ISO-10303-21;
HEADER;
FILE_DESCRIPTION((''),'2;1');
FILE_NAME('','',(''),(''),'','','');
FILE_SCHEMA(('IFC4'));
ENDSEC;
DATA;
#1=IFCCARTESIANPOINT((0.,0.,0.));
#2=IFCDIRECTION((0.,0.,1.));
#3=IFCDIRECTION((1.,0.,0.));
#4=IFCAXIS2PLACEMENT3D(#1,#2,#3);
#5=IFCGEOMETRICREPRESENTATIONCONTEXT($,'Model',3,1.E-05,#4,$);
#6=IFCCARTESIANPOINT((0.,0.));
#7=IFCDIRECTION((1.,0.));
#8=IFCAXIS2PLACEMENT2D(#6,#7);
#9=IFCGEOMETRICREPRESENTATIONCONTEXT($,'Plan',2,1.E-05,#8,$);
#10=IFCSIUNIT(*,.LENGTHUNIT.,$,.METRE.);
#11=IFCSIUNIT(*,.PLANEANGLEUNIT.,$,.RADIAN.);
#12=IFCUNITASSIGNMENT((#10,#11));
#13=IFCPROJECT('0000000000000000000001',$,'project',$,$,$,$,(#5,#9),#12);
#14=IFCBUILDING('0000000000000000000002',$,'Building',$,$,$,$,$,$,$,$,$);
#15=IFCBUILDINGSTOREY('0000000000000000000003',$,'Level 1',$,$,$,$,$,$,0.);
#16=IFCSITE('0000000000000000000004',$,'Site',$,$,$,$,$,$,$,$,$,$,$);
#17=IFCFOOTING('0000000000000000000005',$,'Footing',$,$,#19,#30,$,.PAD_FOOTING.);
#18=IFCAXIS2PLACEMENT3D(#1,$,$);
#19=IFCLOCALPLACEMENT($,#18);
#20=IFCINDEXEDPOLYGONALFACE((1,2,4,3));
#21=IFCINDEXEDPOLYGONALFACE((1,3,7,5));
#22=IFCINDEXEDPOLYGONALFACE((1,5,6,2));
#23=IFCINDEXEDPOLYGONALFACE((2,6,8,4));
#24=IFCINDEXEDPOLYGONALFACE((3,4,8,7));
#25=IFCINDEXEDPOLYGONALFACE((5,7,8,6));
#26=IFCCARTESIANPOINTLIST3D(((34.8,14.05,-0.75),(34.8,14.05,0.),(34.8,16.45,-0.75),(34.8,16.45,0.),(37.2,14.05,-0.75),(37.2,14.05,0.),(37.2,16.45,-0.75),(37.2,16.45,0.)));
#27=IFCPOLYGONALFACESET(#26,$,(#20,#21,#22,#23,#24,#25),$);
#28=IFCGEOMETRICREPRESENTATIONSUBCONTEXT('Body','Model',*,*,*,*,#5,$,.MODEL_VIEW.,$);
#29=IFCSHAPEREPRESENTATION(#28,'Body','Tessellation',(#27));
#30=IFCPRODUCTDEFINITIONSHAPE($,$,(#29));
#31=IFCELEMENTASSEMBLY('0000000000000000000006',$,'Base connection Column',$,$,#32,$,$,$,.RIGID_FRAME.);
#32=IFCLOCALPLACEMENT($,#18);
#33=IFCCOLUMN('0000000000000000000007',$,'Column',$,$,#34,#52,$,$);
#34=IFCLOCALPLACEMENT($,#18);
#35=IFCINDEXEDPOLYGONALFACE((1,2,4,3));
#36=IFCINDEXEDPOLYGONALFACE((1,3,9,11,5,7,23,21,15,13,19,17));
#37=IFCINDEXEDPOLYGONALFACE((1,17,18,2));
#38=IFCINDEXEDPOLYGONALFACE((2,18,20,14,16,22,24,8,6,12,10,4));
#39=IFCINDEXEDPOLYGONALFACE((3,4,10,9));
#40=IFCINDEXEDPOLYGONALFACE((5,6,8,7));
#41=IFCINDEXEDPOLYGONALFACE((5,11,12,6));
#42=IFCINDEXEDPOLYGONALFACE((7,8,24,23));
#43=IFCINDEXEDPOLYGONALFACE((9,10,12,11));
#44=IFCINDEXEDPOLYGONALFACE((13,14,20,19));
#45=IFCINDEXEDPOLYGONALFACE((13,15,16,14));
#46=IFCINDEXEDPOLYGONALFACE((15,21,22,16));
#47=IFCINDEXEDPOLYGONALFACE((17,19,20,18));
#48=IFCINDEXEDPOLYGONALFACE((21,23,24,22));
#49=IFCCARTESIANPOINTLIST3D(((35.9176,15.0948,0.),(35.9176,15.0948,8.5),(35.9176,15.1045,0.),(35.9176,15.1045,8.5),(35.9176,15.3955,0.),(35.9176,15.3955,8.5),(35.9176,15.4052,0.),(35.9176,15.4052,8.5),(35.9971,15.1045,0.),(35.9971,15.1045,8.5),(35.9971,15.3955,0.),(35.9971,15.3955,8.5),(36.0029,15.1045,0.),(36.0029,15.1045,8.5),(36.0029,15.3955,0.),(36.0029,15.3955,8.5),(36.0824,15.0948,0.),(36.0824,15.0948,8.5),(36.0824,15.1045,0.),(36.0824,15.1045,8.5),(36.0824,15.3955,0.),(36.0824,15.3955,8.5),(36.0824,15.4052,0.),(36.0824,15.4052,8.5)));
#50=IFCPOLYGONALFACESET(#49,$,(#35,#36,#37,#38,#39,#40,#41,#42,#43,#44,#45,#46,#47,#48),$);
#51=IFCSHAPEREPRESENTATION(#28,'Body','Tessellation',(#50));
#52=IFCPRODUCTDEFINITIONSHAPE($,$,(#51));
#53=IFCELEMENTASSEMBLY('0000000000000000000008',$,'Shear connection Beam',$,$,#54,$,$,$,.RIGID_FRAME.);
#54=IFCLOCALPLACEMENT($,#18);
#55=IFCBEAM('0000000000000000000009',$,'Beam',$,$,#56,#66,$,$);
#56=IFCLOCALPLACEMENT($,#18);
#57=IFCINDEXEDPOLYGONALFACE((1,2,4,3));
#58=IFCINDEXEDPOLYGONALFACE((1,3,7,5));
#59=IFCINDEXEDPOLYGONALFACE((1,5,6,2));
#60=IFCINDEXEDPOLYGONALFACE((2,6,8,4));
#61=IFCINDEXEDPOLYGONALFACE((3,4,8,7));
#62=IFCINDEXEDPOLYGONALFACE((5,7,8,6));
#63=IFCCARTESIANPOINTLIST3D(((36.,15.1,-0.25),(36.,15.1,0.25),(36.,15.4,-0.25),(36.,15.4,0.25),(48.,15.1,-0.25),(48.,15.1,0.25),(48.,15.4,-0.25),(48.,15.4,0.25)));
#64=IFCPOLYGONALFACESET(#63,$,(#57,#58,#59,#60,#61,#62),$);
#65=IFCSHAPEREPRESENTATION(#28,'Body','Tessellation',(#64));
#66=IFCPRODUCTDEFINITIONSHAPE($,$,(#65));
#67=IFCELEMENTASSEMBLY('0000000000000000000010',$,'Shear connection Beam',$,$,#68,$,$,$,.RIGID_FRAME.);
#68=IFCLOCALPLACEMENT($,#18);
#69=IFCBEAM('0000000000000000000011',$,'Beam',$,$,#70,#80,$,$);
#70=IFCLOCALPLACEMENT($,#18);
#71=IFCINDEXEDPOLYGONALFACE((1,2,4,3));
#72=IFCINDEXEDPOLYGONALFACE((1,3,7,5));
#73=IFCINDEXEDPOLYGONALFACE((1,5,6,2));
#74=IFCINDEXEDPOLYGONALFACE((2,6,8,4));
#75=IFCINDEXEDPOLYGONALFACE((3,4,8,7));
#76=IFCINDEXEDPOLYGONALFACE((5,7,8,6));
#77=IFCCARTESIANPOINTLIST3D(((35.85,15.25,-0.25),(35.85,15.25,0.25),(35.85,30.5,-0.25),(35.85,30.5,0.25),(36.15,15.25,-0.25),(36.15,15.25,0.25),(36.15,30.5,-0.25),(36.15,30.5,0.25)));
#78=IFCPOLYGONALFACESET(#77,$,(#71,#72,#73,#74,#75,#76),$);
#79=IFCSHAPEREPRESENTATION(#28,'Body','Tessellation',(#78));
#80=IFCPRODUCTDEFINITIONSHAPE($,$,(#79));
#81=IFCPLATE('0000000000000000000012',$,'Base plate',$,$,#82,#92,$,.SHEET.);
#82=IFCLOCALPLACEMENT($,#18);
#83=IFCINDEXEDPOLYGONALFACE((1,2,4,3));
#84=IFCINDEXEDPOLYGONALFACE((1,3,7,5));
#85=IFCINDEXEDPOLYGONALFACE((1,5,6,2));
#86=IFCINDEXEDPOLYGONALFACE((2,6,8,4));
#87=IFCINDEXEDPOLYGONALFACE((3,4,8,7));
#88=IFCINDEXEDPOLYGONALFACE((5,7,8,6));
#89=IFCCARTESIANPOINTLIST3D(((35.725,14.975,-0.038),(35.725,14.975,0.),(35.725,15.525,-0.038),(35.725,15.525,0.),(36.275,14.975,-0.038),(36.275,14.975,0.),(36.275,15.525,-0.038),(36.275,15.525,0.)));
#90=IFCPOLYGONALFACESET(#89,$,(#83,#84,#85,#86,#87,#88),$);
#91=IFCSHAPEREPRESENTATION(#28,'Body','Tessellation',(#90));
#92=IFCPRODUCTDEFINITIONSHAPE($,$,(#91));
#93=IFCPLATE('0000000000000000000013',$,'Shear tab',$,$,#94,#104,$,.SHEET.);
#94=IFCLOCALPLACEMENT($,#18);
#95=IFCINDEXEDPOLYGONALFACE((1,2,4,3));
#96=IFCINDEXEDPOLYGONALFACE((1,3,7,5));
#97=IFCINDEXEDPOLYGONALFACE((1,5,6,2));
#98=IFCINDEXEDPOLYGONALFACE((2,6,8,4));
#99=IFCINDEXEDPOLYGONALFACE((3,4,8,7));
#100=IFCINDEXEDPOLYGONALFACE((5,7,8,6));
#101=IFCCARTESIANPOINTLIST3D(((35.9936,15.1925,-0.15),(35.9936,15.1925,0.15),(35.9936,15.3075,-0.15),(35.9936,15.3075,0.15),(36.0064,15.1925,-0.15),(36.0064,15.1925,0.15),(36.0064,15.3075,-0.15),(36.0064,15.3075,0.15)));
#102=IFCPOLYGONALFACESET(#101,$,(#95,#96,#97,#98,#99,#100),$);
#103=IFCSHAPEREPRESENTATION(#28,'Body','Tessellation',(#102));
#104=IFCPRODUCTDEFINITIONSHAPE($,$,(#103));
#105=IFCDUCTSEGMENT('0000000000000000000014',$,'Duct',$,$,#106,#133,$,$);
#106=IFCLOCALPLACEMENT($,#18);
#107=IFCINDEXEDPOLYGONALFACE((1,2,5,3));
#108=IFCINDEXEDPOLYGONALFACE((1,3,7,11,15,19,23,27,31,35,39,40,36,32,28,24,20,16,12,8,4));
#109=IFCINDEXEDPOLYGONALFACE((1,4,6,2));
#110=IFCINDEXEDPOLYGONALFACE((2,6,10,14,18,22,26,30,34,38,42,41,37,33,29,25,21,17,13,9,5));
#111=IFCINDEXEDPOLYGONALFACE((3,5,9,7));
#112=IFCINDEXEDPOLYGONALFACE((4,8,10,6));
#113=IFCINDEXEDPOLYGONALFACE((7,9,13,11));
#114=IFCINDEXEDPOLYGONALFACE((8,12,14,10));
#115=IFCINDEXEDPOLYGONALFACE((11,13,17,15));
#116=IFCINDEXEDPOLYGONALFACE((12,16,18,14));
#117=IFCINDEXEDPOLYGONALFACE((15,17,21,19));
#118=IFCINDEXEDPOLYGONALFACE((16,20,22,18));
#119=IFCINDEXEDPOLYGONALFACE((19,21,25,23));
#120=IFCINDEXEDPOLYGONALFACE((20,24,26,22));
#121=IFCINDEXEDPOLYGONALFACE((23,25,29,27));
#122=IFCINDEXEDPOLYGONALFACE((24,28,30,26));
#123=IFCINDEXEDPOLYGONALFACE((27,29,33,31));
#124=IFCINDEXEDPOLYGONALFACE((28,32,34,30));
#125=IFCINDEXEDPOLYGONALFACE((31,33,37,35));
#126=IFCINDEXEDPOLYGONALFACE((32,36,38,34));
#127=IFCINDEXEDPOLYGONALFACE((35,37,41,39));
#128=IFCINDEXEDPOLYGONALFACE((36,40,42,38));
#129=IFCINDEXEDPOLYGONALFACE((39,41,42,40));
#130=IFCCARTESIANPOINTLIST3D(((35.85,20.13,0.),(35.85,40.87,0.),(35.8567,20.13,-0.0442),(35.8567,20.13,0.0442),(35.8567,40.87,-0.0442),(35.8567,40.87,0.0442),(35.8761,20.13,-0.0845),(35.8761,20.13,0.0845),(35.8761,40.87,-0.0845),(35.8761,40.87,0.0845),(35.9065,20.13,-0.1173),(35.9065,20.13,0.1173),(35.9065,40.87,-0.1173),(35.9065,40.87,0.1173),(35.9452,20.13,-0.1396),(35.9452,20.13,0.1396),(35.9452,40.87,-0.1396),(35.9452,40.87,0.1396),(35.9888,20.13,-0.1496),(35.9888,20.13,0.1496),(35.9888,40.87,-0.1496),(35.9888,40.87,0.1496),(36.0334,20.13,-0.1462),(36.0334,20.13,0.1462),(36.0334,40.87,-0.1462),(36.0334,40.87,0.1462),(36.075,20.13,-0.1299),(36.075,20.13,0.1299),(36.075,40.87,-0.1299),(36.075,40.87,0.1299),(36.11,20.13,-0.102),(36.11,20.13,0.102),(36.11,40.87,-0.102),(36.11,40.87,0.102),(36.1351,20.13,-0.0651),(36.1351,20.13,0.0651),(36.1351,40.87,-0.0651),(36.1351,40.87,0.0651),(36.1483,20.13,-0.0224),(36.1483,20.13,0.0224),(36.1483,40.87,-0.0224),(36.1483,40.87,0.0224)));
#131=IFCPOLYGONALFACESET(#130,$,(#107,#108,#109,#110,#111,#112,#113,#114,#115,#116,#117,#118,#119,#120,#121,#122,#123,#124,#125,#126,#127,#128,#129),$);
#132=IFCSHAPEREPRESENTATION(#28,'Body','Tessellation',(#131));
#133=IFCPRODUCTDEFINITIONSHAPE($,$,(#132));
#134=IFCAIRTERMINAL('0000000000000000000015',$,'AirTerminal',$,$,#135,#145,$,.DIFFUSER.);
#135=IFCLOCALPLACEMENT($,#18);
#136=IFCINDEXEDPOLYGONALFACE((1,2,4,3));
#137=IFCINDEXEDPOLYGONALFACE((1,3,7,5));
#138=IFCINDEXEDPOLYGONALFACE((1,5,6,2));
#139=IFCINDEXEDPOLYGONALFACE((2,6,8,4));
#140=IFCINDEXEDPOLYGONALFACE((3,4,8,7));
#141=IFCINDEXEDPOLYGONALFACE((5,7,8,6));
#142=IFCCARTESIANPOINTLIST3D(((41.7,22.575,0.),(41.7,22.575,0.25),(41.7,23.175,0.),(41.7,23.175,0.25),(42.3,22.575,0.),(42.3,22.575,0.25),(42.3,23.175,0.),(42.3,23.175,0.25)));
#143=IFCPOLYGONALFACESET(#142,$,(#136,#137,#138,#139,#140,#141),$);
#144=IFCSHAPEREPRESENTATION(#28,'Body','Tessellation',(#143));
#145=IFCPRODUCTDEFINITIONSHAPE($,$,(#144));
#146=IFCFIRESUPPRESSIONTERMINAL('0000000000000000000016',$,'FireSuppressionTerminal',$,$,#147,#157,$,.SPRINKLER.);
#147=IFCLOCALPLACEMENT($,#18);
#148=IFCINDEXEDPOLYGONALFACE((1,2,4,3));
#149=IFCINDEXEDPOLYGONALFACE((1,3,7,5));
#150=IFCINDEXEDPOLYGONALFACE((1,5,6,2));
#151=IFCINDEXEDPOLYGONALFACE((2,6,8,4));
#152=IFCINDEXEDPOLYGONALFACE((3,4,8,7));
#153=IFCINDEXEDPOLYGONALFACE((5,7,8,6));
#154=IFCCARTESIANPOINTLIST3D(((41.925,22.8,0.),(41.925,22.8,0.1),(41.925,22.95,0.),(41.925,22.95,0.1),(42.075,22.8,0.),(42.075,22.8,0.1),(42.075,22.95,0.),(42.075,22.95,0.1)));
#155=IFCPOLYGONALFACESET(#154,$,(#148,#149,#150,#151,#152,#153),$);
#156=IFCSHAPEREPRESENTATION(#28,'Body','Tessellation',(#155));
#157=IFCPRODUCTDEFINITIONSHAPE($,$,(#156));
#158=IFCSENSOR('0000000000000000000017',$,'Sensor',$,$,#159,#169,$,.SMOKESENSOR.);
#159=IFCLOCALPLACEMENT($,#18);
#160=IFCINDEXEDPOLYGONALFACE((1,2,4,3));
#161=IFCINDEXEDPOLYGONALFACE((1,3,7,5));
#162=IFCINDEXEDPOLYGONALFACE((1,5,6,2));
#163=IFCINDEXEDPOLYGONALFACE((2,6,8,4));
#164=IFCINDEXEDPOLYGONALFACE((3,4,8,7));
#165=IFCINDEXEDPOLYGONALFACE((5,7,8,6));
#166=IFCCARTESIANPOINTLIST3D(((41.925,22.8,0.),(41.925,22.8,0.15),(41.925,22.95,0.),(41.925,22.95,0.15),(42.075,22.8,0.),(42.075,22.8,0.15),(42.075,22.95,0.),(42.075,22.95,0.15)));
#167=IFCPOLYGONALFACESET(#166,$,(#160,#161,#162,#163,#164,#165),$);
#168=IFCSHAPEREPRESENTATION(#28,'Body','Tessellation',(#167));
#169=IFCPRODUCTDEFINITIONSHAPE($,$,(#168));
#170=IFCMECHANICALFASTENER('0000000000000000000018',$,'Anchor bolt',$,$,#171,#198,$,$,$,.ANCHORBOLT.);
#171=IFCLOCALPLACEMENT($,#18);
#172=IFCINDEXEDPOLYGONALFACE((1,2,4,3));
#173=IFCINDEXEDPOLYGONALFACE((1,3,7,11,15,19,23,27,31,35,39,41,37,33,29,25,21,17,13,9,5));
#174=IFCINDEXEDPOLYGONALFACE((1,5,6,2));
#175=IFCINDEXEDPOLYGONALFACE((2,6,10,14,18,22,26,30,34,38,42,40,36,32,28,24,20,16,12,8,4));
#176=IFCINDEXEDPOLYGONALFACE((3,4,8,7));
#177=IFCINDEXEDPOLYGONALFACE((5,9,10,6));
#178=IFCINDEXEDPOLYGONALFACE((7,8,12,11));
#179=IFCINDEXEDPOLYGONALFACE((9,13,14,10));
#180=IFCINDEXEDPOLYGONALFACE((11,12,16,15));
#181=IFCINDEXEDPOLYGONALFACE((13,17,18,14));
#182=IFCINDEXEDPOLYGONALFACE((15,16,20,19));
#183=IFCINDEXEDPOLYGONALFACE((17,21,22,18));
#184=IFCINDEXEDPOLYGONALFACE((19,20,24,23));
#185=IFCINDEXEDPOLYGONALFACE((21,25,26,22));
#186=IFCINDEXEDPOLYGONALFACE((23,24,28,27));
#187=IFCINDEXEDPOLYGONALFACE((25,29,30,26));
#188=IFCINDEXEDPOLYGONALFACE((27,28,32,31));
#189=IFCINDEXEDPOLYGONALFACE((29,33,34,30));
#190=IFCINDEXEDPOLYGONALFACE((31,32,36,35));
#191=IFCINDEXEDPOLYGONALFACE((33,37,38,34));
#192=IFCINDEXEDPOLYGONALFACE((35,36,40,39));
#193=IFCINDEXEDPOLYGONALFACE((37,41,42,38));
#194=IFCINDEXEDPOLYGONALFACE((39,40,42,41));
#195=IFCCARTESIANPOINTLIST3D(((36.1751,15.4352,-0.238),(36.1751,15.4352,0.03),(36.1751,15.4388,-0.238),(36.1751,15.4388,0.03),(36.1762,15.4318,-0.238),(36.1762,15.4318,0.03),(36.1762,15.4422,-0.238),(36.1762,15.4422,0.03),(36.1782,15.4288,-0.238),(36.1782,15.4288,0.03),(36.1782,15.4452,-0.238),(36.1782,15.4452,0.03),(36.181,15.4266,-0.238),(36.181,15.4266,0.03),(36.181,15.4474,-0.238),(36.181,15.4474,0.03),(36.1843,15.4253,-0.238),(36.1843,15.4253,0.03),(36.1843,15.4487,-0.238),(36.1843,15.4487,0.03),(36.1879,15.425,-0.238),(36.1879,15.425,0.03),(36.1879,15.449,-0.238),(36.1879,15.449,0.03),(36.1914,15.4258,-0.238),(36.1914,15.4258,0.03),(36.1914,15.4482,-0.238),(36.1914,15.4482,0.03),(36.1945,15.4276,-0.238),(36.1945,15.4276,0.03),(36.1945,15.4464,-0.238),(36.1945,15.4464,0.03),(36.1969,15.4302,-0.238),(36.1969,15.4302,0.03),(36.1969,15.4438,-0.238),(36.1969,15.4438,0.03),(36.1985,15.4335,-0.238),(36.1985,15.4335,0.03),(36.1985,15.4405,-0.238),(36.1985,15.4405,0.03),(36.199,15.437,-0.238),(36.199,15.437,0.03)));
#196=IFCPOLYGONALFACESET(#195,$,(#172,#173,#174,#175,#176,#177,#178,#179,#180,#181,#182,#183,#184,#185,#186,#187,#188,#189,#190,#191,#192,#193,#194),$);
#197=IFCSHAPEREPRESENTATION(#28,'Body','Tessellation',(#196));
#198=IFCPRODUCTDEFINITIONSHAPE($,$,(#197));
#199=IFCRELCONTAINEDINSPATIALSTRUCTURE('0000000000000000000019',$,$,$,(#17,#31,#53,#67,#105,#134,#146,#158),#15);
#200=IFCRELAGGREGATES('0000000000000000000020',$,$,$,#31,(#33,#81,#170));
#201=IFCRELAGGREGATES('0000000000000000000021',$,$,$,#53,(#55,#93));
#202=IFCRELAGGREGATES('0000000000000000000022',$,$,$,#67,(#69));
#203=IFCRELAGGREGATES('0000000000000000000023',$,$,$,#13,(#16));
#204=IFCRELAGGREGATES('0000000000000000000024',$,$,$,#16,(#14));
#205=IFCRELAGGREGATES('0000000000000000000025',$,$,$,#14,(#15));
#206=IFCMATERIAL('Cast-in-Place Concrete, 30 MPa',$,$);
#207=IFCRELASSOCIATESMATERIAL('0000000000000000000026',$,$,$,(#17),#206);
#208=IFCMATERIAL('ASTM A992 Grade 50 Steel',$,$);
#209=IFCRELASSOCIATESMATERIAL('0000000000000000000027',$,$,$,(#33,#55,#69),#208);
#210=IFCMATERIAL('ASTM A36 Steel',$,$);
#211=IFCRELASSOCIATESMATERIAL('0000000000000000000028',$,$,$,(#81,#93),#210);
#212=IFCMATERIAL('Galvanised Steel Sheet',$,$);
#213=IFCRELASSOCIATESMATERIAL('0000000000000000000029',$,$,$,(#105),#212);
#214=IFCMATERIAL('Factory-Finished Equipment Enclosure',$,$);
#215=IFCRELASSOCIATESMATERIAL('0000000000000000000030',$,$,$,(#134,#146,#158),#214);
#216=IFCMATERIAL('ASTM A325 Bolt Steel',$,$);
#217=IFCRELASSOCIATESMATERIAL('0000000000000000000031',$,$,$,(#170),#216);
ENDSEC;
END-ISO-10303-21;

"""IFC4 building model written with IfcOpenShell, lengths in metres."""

from ifc_helpers import new_model, si_unit, frame, origin_with_axes, origin_2d, origin_2d_with_axis, place, context, subcontext, project, spatial, rectangle, circle, i_section, extrude, material, element, aggregate, save


model = new_model("IFC4")

# Units and contexts
model_context = context("Model", 3, precision=1e-05, world=origin_with_axes())
plan_context = context("Plan", 2, precision=1e-05, world=origin_2d_with_axis())
body_context = subcontext(model_context, "Body", "Model", "MODEL_VIEW")
ifc_project = project(units=[si_unit("LENGTHUNIT", "METRE"), si_unit("PLANEANGLEUNIT", "RADIAN")], contexts=[model_context, plan_context])

# Site, building, storey
site = spatial("IfcSite", under=ifc_project, Name="Site")
building = spatial("IfcBuilding", under=site, Name="Building")
storey = spatial("IfcBuildingStorey", under=building, Name="Level 1", Elevation=0.0)

# Footing
ifc_material_1 = material(Name="Cast-in-Place Concrete, 30 MPa")
footing_placement = place(None, frame((36.0, 15.25, -0.75), z_axis=(0.0, 0.0, 1.0), x_axis=(1.0, 0.0, 0.0)))
element("IfcFooting", 1, at=footing_placement, inside=storey, material=ifc_material_1, Name="Footing", PredefinedType="PAD_FOOTING", context=body_context, shape_type="SweptSolid", body=[
    extrude(rectangle(XDim=2.4, YDim=2.4, at=origin_2d_with_axis()), origin_with_axes(), (0.0, 0.0, 1.0), 0.75),
])

# Element assembly, column
assembly_1 = element("IfcElementAssembly", 2, inside=storey, Name="Base connection Column", PredefinedType="RIGID_FRAME")
ifc_material_2 = material(Name="ASTM A992 Grade 50 Steel")
column_placement = place(None, frame((36.0, 15.25, 0.0), z_axis=(0.0, 0.0, 1.0), x_axis=(1.0, 0.0, 0.0)))
column = element("IfcColumn", 3, at=column_placement, material=ifc_material_2, Name="Column", context=body_context, shape_type="SweptSolid", body=[
    extrude(i_section(OverallWidth=0.1648, OverallDepth=0.3104, WebThickness=0.0058, FlangeThickness=0.0097, at=origin_2d_with_axis()), origin_with_axes(), (0.0, 0.0, 1.0), 8.5),
])

# Element assemblies, beams
assembly_2 = element("IfcElementAssembly", 4, inside=storey, Name="Shear connection Beam", PredefinedType="RIGID_FRAME")
beam_1_placement = place(None, frame((36.0, 15.25, 0.0), z_axis=(1.0, 0.0, 0.0), x_axis=(0.0, 1.0, 0.0)))
beam_1 = element("IfcBeam", 5, at=beam_1_placement, material=ifc_material_2, Name="Beam", context=body_context, shape_type="SweptSolid", body=[
    extrude(rectangle(XDim=0.3, YDim=0.5, at=origin_2d_with_axis()), origin_with_axes(), (0.0, 0.0, 1.0), 12.0),
])
assembly_3 = element("IfcElementAssembly", 6, inside=storey, Name="Shear connection Beam", PredefinedType="RIGID_FRAME")
beam_2_placement = place(None, frame((36.0, 15.25, 0.0), z_axis=(0.0, 1.0, 0.0), x_axis=(-1.0, 0.0, 0.0)))
beam_2 = element("IfcBeam", 7, at=beam_2_placement, material=ifc_material_2, Name="Beam", context=body_context, shape_type="SweptSolid", body=[
    extrude(rectangle(XDim=0.3, YDim=0.5, at=origin_2d_with_axis()), origin_with_axes(), (0.0, 0.0, 1.0), 15.25),
])

# Plates
ifc_material_3 = material(Name="ASTM A36 Steel")
plate_1_placement = place(None, frame((36.0, 15.25, -0.038), z_axis=(0.0, 0.0, 1.0), x_axis=(1.0, 0.0, 0.0)))
plate_1 = element("IfcPlate", 8, at=plate_1_placement, material=ifc_material_3, Name="Base plate", PredefinedType="SHEET", context=body_context, shape_type="SweptSolid", body=[
    extrude(rectangle(XDim=0.55, YDim=0.55, at=origin_2d_with_axis()), origin_with_axes(), (0.0, 0.0, 1.0), 0.038),
])
plate_2_placement = place(None, frame((36.0, 15.25, -0.15), z_axis=(0.0, 0.0, 1.0), x_axis=(1.0, 0.0, 0.0)))
plate_2 = element("IfcPlate", 9, at=plate_2_placement, material=ifc_material_3, Name="Shear tab", PredefinedType="SHEET", context=body_context, shape_type="SweptSolid", body=[
    extrude(rectangle(XDim=0.0127, YDim=0.115, at=origin_2d_with_axis()), origin_with_axes(), (0.0, 0.0, 1.0), 0.3),
])

# Duct segment
ifc_material_4 = material(Name="Galvanised Steel Sheet")
duct_segment_placement = place(None, frame((36.0, 20.13, 0.0), z_axis=(0.0, 1.0, 0.0), x_axis=(-1.0, 0.0, 0.0)))
element("IfcDuctSegment", 10, at=duct_segment_placement, inside=storey, material=ifc_material_4, Name="Duct", context=body_context, shape_type="SweptSolid", body=[
    extrude(circle(Radius=0.15, at=origin_2d_with_axis()), origin_with_axes(), (0.0, 0.0, 1.0), 20.74),
])

# Air terminal
ifc_material_5 = material(Name="Factory-Finished Equipment Enclosure")
air_terminal_placement = place(None, frame((42.0, 22.875, 0.0), z_axis=(0.0, 0.0, 1.0), x_axis=(1.0, 0.0, 0.0)))
element("IfcAirTerminal", 11, at=air_terminal_placement, inside=storey, material=ifc_material_5, Name="AirTerminal", PredefinedType="DIFFUSER", context=body_context, shape_type="SweptSolid", body=[
    extrude(rectangle(XDim=0.6, YDim=0.6, at=origin_2d_with_axis()), origin_with_axes(), (0.0, 0.0, 1.0), 0.25),
])

# Fire suppression terminal
fire_suppression_terminal_placement = place(None, frame((42.0, 22.875, 0.0), z_axis=(0.0, 0.0, 1.0), x_axis=(1.0, 0.0, 0.0)))
element("IfcFireSuppressionTerminal", 12, at=fire_suppression_terminal_placement, inside=storey, material=ifc_material_5, Name="FireSuppressionTerminal", PredefinedType="SPRINKLER", context=body_context, shape_type="SweptSolid", body=[
    extrude(rectangle(XDim=0.15, YDim=0.15, at=origin_2d_with_axis()), origin_with_axes(), (0.0, 0.0, 1.0), 0.1),
])

# Sensor
sensor_placement = place(None, frame((42.0, 22.875, 0.0), z_axis=(0.0, 0.0, 1.0), x_axis=(1.0, 0.0, 0.0)))
element("IfcSensor", 13, at=sensor_placement, inside=storey, material=ifc_material_5, Name="Sensor", PredefinedType="SMOKESENSOR", context=body_context, shape_type="SweptSolid", body=[
    extrude(rectangle(XDim=0.15, YDim=0.15, at=origin_2d_with_axis()), origin_with_axes(), (0.0, 0.0, 1.0), 0.15),
])

# Mechanical fastener
ifc_material_6 = material(Name="ASTM A325 Bolt Steel")
mechanical_fastener_1_placement = place(None, frame((36.187, 15.437, -0.238), z_axis=(0.0, 0.0, 1.0), x_axis=(1.0, 0.0, 0.0)))
mechanical_fastener_1 = element("IfcMechanicalFastener", 14, at=mechanical_fastener_1_placement, material=ifc_material_6, Name="Anchor bolt", PredefinedType="ANCHORBOLT", context=body_context, shape_type="SweptSolid", body=[
    extrude(circle(Radius=0.012, at=origin_2d()), origin_with_axes(), (0.0, 0.0, 1.0), 0.268),
])
aggregate(assembly_1, [column, plate_1, mechanical_fastener_1])

aggregate(assembly_2, [beam_1, plate_2])

aggregate(assembly_3, [beam_2])

save(model, "model.ifc")
